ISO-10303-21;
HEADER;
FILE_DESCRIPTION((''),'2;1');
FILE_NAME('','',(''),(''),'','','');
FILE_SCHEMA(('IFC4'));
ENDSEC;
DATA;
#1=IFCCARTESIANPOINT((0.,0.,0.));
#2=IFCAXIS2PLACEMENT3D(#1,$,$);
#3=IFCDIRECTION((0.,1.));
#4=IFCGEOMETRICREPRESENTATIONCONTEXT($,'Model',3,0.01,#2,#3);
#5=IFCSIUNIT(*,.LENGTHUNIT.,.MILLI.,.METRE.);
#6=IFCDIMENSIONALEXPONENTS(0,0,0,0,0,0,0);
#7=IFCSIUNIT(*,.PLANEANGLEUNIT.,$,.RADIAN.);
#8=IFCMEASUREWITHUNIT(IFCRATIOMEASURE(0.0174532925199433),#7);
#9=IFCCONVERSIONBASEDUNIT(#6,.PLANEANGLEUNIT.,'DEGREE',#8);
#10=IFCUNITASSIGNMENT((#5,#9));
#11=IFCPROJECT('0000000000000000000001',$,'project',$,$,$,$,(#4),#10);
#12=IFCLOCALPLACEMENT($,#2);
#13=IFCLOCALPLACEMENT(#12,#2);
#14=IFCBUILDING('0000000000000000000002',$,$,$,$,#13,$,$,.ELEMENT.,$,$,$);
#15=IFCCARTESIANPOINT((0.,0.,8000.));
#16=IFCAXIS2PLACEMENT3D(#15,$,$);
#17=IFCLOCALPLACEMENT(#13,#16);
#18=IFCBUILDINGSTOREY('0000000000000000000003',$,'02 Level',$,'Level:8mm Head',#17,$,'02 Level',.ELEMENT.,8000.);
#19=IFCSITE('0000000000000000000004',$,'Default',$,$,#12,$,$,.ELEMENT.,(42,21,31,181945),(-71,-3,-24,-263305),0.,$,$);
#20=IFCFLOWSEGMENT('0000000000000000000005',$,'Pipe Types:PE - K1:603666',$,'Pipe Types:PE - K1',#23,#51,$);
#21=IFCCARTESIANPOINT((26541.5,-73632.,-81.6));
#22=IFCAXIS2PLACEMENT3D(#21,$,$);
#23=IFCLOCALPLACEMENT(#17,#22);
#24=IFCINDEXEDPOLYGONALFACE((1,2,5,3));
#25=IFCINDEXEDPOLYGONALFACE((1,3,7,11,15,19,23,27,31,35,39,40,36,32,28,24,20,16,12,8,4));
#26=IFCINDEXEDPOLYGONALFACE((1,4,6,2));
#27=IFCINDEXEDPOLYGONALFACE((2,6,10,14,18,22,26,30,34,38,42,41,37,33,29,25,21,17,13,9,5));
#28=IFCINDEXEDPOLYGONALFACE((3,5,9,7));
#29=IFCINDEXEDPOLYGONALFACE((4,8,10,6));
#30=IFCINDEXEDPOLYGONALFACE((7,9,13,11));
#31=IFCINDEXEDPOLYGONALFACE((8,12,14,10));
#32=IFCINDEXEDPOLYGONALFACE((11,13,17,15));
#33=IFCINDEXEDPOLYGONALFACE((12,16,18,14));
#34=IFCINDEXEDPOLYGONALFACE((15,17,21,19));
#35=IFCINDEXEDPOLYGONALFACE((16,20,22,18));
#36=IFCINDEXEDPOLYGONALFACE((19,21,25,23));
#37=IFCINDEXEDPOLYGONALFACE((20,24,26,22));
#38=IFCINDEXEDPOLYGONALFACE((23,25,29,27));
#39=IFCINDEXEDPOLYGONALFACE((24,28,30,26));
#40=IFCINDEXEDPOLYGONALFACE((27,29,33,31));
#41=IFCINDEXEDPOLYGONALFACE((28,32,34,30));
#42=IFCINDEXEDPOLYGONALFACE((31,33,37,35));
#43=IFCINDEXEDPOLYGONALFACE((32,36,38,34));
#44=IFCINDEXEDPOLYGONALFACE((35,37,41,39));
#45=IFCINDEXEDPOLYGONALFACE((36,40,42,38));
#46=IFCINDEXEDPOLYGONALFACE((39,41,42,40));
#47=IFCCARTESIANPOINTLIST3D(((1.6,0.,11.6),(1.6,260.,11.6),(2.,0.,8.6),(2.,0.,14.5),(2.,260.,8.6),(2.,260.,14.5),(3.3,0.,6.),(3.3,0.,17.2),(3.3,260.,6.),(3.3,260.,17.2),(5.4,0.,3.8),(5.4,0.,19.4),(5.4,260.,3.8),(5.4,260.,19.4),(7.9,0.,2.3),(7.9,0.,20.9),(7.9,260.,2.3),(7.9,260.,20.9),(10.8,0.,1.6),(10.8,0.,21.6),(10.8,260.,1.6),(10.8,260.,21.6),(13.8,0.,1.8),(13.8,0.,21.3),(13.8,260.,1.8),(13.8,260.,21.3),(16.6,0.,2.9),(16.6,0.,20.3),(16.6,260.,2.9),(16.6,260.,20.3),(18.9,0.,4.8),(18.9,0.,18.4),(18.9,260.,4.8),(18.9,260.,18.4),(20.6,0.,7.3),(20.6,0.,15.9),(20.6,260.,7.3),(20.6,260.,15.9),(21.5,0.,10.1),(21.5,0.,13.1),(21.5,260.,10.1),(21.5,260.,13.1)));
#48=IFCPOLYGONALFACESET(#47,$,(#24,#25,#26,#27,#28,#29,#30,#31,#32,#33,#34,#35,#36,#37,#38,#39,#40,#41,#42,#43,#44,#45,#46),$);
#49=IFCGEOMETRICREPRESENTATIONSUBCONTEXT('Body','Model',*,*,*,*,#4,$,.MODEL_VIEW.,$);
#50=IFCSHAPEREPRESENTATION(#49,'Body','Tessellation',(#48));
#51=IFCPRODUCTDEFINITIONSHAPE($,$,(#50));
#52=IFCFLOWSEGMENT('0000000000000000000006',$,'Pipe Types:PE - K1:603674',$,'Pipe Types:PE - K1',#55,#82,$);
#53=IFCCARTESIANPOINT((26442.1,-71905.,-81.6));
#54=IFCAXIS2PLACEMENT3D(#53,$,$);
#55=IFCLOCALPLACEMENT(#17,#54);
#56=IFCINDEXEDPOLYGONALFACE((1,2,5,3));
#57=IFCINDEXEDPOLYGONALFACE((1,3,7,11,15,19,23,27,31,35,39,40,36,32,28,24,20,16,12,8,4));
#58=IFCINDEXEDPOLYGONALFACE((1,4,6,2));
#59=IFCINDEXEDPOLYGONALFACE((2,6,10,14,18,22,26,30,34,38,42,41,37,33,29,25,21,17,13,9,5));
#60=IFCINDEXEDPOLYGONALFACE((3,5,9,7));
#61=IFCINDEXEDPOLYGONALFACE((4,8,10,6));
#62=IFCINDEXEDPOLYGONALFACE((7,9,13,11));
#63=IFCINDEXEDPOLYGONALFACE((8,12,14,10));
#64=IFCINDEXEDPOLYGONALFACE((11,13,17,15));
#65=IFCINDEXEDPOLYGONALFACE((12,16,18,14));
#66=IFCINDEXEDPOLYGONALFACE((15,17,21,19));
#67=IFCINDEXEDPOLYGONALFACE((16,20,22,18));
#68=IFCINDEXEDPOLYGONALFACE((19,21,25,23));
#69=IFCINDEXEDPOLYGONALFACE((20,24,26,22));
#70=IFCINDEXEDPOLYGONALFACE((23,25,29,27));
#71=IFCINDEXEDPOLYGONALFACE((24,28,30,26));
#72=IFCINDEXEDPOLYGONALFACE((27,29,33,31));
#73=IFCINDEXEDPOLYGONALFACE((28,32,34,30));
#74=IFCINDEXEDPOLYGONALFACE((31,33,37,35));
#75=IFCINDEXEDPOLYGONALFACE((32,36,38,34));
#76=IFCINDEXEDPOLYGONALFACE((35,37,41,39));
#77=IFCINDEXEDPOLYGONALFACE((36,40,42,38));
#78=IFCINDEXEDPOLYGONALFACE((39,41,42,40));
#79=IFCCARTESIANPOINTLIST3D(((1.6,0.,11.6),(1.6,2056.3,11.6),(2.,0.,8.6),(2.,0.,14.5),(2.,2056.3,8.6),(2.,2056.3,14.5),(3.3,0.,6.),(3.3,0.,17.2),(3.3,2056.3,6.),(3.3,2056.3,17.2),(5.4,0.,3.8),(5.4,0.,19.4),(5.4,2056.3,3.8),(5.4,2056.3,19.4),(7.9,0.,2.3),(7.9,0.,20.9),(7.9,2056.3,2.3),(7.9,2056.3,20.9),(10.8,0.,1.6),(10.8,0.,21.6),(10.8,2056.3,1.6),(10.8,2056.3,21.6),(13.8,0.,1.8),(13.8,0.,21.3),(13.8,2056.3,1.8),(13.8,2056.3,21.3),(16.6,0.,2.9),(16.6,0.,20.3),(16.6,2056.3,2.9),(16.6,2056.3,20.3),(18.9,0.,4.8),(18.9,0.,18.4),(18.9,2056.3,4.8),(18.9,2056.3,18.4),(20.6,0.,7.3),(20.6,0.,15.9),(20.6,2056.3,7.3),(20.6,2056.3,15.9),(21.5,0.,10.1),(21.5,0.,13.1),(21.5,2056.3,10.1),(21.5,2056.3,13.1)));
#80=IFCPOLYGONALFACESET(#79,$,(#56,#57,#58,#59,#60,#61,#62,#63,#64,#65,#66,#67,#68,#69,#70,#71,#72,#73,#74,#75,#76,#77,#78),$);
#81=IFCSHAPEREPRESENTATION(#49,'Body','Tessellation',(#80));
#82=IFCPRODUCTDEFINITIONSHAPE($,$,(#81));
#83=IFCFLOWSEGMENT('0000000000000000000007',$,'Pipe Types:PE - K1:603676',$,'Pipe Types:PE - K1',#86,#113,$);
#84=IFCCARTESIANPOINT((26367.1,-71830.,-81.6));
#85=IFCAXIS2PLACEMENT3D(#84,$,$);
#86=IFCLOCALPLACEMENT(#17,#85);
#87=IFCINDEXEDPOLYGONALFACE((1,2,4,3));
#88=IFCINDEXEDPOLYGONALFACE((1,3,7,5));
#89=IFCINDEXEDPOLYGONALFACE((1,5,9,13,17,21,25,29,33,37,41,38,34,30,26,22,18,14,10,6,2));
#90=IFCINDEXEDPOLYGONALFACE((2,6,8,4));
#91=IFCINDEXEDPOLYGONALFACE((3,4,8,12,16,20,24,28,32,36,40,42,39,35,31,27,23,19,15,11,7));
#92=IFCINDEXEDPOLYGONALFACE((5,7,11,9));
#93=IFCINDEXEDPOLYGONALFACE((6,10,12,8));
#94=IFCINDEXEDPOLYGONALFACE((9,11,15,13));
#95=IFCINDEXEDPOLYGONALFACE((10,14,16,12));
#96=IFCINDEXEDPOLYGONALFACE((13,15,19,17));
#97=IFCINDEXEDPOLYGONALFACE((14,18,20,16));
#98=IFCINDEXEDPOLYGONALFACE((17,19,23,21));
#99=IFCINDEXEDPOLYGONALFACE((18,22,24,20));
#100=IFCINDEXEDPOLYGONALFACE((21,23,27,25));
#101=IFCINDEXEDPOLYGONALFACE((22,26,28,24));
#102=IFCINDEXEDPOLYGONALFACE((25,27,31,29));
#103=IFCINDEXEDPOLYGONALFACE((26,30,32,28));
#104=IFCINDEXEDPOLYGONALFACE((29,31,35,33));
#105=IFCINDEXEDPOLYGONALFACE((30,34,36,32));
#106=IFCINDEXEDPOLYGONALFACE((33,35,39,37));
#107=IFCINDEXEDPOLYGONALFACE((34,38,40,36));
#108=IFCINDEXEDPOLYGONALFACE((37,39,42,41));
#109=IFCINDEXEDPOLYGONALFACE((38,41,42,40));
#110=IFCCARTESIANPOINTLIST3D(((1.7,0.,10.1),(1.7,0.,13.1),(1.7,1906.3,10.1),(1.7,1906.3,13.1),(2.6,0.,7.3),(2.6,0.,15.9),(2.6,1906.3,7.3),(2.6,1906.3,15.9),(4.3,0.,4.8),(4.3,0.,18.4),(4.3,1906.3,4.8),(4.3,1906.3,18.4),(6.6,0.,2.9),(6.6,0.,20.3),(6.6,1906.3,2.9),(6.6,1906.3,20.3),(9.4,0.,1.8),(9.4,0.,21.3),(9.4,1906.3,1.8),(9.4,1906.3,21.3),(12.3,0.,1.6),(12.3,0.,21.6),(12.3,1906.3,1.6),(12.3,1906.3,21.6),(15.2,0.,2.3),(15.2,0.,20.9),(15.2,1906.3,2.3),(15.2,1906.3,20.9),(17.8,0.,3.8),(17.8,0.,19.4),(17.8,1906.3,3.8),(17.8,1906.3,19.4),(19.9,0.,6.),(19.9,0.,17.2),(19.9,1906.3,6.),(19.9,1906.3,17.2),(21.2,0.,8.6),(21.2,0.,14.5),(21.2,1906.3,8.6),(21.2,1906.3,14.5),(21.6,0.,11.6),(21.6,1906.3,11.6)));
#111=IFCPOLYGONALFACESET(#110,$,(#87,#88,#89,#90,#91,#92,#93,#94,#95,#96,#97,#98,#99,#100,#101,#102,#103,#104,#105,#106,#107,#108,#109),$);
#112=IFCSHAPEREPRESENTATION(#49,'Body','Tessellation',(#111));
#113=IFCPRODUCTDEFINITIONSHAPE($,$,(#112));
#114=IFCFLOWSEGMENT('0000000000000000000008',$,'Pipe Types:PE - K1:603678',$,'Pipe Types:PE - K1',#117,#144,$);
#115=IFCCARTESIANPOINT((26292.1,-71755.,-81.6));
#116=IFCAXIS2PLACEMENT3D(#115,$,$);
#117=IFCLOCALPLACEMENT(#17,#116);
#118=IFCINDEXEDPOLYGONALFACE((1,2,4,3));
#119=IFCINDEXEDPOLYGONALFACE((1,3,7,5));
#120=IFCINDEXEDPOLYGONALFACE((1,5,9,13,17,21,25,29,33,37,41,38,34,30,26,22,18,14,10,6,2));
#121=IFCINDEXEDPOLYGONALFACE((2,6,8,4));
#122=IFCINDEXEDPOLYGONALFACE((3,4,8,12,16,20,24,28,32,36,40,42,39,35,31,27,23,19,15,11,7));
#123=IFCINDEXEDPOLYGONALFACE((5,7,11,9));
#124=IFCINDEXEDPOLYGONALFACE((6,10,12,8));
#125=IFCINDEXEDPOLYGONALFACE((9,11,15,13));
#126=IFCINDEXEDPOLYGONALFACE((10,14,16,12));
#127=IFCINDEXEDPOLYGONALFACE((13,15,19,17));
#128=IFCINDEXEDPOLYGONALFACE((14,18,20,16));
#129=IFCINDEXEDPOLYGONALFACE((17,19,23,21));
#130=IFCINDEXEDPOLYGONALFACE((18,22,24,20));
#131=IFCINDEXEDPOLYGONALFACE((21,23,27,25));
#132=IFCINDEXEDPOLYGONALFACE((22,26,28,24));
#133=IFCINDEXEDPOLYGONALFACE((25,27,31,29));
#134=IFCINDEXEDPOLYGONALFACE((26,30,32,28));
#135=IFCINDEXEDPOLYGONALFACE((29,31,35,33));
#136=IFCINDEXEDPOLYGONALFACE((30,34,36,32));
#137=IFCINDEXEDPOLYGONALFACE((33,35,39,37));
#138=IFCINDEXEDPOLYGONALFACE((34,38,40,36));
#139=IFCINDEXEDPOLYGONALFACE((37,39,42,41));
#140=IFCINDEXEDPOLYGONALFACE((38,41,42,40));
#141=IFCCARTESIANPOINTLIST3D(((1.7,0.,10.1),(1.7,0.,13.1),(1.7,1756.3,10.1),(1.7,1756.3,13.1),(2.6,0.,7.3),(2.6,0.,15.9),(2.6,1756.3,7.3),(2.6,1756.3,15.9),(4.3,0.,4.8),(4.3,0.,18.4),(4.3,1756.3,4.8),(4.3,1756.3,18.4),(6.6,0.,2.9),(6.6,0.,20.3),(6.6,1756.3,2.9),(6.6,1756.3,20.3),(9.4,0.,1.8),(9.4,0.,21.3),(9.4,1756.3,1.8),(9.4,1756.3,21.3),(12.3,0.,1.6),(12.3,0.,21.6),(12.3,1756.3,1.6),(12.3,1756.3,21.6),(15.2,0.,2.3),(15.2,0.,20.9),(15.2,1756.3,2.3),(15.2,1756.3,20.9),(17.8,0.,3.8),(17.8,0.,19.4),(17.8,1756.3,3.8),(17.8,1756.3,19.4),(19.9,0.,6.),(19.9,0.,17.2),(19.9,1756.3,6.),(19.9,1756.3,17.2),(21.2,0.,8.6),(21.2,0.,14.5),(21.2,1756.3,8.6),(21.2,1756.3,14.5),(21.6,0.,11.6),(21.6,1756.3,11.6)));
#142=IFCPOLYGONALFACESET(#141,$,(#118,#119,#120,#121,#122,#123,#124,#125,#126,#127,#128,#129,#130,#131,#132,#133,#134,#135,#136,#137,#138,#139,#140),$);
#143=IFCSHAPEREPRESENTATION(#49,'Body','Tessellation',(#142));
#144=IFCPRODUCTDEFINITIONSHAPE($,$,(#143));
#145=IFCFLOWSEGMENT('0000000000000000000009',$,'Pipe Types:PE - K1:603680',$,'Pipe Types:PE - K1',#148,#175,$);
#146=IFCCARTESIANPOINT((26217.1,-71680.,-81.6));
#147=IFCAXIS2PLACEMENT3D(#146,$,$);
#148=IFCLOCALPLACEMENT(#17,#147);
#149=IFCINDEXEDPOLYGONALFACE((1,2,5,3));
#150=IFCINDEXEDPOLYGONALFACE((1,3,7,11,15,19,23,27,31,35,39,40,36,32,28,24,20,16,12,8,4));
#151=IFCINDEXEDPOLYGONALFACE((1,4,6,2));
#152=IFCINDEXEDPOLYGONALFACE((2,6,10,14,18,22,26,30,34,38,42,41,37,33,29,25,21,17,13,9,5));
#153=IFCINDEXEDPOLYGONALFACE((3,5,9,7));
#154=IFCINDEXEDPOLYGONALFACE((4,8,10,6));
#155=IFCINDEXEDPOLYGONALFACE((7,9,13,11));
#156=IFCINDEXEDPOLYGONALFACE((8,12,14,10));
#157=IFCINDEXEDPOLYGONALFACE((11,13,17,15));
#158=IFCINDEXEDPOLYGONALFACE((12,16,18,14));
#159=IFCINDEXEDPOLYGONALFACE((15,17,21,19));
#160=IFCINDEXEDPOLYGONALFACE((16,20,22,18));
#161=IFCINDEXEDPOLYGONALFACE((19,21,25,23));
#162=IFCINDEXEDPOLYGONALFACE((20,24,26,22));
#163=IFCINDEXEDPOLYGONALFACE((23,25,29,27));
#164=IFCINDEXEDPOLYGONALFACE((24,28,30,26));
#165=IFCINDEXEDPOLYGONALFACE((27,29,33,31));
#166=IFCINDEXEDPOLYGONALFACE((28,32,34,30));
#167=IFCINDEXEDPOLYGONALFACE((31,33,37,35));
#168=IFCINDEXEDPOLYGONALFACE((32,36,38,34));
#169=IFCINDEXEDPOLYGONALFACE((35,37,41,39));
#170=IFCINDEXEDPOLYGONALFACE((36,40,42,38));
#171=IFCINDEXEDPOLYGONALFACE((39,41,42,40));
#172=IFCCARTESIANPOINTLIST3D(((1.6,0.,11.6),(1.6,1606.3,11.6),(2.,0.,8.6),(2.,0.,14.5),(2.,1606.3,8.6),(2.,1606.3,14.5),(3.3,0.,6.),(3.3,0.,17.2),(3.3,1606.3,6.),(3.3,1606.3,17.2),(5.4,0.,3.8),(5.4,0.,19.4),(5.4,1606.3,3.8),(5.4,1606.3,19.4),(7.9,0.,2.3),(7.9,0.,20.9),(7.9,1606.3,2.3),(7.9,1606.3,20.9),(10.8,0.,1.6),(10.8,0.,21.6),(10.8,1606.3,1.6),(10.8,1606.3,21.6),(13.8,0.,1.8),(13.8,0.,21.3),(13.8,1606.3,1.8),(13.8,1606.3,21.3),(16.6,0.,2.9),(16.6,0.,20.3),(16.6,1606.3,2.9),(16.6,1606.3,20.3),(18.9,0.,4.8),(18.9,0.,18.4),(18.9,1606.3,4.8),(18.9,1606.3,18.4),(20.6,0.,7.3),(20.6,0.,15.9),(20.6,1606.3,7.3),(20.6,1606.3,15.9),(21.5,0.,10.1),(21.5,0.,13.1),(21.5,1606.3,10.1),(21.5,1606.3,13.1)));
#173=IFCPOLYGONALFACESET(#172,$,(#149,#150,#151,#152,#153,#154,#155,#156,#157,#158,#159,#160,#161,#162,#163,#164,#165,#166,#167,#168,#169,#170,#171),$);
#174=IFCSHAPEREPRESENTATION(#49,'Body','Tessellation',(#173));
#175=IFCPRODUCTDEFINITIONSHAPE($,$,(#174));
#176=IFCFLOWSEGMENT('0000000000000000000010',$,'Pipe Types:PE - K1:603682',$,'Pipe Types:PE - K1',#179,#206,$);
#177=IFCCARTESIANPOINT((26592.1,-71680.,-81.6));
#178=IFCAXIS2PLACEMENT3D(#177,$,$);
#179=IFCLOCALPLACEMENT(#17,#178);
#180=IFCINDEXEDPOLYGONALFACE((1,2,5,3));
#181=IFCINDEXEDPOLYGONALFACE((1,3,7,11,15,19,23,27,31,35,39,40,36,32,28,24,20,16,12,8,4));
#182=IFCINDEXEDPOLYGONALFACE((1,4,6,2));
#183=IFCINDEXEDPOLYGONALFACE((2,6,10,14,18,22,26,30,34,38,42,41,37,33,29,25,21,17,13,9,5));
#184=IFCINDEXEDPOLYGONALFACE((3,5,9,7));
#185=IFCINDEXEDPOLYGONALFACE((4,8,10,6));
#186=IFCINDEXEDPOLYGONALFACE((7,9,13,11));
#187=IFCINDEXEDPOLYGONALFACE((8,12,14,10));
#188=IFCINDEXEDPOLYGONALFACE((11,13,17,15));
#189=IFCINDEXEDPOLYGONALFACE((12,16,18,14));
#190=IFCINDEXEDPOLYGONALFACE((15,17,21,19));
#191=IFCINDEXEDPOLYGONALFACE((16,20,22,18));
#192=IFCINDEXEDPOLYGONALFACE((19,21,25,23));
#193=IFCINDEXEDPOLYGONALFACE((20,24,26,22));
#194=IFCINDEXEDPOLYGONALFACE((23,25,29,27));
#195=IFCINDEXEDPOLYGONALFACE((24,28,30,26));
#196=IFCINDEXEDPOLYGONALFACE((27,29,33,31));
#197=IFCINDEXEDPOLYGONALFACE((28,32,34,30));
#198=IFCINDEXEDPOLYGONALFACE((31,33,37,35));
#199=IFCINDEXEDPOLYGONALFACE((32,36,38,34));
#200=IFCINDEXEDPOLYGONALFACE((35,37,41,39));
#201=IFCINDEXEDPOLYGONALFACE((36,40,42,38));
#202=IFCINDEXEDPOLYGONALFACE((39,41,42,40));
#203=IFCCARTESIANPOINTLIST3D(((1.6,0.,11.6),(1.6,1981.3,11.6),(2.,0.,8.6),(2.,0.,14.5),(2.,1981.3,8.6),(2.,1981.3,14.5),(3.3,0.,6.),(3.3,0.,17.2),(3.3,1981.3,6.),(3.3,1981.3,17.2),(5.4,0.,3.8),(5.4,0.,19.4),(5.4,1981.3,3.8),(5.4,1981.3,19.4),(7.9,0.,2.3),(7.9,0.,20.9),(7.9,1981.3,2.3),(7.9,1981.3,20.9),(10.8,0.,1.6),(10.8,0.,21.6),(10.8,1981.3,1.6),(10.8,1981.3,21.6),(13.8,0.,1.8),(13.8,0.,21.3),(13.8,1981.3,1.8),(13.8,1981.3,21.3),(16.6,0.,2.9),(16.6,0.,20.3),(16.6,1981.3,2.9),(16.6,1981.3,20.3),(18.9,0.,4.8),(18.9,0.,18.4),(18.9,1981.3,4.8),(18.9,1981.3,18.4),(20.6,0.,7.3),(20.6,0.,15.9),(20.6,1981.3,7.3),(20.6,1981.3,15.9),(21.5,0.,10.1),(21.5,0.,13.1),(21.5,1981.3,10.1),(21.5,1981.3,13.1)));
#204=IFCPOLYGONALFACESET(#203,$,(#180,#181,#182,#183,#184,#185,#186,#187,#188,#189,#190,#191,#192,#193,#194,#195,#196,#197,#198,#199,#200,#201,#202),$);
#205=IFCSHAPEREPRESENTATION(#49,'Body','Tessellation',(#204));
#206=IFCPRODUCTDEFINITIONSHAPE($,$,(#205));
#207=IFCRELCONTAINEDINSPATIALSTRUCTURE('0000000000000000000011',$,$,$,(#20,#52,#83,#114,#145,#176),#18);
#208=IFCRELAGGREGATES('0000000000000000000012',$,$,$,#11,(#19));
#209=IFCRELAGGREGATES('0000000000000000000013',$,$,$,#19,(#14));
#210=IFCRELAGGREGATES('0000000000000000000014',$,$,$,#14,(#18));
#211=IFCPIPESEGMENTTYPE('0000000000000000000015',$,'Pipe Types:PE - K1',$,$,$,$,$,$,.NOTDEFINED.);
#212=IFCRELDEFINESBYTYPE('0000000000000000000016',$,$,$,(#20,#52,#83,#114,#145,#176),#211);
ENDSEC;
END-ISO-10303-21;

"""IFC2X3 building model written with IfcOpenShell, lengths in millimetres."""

from ifc_helpers import new_model, entity, si_unit, converted_unit, direction, frame, frame_2d, origin, origin_2d_with_axis, place, context, subcontext, project, spatial, circle, extrude, type_object, element, save


model = new_model("IFC2X3")

# Units and contexts
model_context = context("Model", 3, precision=0.01, world=origin(), true_north=direction((0.0, 1.0)))
body_context = subcontext(model_context, "Body", "Model", "MODEL_VIEW")
ifc_project = project(units=[si_unit("LENGTHUNIT", "METRE", prefix="MILLI"), converted_unit("PLANEANGLEUNIT", "DEGREE", entity("IfcRatioMeasure", 0.0174532925199433), si_unit("PLANEANGLEUNIT", "RADIAN"), dimensions=[0, 0, 0, 0, 0, 0, 0])], contexts=[model_context])

# Site, building, storey
site_placement = place(None, origin())
site = spatial("IfcSite", under=ifc_project, at=site_placement, Name="Default", CompositionType="ELEMENT", RefLatitude=(42, 21, 31, 181945), RefLongitude=(-71, -3, -24, -263305), RefElevation=0.0)
building_placement = place(site_placement, origin())
building = spatial("IfcBuilding", under=site, at=building_placement, CompositionType="ELEMENT")
storey_placement = place(building_placement, frame((0.0, 0.0, 8000.0)))
storey = spatial("IfcBuildingStorey", under=building, at=storey_placement, Name="02 Level", ObjectType="Level:8mm Head", LongName="02 Level", CompositionType="ELEMENT", Elevation=8000.0)

# Flow segments
pipe_segment_type = type_object("IfcPipeSegmentType", Name="Pipe Types:PE - K1", PredefinedType="NOTDEFINED")
flow_segment_1_placement = place(storey_placement, frame((26541.5, -73632.0, -81.6)))
element("IfcFlowSegment", 1, at=flow_segment_1_placement, inside=storey, type_object=pipe_segment_type, Name="Pipe Types:PE - K1:603666", ObjectType="Pipe Types:PE - K1", context=body_context, shape_type="SweptSolid", body=[
    extrude(circle(Radius=10.0, at=frame_2d((0.0, 0.0), x_axis=(1.0, 0.0))), frame((11.6, 0.0, 11.6), z_axis=(0.0, 1.0, 0.0), x_axis=(-1.0, 0.0, 0.0)), (0.0, 0.0, 1.0), 260.0),
])
flow_segment_2_placement = place(storey_placement, frame((26442.1, -71905.0, -81.6)))
element("IfcFlowSegment", 2, at=flow_segment_2_placement, inside=storey, type_object=pipe_segment_type, Name="Pipe Types:PE - K1:603674", ObjectType="Pipe Types:PE - K1", context=body_context, shape_type="SweptSolid", body=[
    extrude(circle(Radius=10.0, at=origin_2d_with_axis()), frame((11.6, 0.0, 11.6), z_axis=(0.0, 1.0, 0.0), x_axis=(-1.0, 0.0, 0.0)), (0.0, 0.0, 1.0), 2056.3),
])
flow_segment_3_placement = place(storey_placement, frame((26367.1, -71830.0, -81.6)))
element("IfcFlowSegment", 3, at=flow_segment_3_placement, inside=storey, type_object=pipe_segment_type, Name="Pipe Types:PE - K1:603676", ObjectType="Pipe Types:PE - K1", context=body_context, shape_type="SweptSolid", body=[
    extrude(circle(Radius=10.0, at=origin_2d_with_axis()), frame((11.6, 0.0, 11.6), z_axis=(0.0, 1.0, 0.0), x_axis=(1.0, 0.0, 0.0)), (0.0, 0.0, 1.0), 1906.3),
])
flow_segment_4_placement = place(storey_placement, frame((26292.1, -71755.0, -81.6)))
element("IfcFlowSegment", 4, at=flow_segment_4_placement, inside=storey, type_object=pipe_segment_type, Name="Pipe Types:PE - K1:603678", ObjectType="Pipe Types:PE - K1", context=body_context, shape_type="SweptSolid", body=[
    extrude(circle(Radius=10.0, at=origin_2d_with_axis()), frame((11.6, 0.0, 11.6), z_axis=(0.0, 1.0, 0.0), x_axis=(1.0, 0.0, 0.0)), (0.0, 0.0, 1.0), 1756.3),
])
flow_segment_5_placement = place(storey_placement, frame((26217.1, -71680.0, -81.6)))
element("IfcFlowSegment", 5, at=flow_segment_5_placement, inside=storey, type_object=pipe_segment_type, Name="Pipe Types:PE - K1:603680", ObjectType="Pipe Types:PE - K1", context=body_context, shape_type="SweptSolid", body=[
    extrude(circle(Radius=10.0, at=frame_2d((0.0, 0.0), x_axis=(1.0, 0.0))), frame((11.6, 0.0, 11.6), z_axis=(0.0, 1.0, 0.0), x_axis=(-1.0, 0.0, 0.0)), (0.0, 0.0, 1.0), 1606.3),
])
flow_segment_6_placement = place(storey_placement, frame((26592.1, -71680.0, -81.6)))
element("IfcFlowSegment", 6, at=flow_segment_6_placement, inside=storey, type_object=pipe_segment_type, Name="Pipe Types:PE - K1:603682", ObjectType="Pipe Types:PE - K1", context=body_context, shape_type="SweptSolid", body=[
    extrude(circle(Radius=10.0, at=frame_2d((0.0, 0.0), x_axis=(1.0, 0.0))), frame((11.6, 0.0, 11.6), z_axis=(0.0, 1.0, 0.0), x_axis=(-1.0, 0.0, 0.0)), (0.0, 0.0, 1.0), 1981.3),
])

save(model, "model.ifc")
